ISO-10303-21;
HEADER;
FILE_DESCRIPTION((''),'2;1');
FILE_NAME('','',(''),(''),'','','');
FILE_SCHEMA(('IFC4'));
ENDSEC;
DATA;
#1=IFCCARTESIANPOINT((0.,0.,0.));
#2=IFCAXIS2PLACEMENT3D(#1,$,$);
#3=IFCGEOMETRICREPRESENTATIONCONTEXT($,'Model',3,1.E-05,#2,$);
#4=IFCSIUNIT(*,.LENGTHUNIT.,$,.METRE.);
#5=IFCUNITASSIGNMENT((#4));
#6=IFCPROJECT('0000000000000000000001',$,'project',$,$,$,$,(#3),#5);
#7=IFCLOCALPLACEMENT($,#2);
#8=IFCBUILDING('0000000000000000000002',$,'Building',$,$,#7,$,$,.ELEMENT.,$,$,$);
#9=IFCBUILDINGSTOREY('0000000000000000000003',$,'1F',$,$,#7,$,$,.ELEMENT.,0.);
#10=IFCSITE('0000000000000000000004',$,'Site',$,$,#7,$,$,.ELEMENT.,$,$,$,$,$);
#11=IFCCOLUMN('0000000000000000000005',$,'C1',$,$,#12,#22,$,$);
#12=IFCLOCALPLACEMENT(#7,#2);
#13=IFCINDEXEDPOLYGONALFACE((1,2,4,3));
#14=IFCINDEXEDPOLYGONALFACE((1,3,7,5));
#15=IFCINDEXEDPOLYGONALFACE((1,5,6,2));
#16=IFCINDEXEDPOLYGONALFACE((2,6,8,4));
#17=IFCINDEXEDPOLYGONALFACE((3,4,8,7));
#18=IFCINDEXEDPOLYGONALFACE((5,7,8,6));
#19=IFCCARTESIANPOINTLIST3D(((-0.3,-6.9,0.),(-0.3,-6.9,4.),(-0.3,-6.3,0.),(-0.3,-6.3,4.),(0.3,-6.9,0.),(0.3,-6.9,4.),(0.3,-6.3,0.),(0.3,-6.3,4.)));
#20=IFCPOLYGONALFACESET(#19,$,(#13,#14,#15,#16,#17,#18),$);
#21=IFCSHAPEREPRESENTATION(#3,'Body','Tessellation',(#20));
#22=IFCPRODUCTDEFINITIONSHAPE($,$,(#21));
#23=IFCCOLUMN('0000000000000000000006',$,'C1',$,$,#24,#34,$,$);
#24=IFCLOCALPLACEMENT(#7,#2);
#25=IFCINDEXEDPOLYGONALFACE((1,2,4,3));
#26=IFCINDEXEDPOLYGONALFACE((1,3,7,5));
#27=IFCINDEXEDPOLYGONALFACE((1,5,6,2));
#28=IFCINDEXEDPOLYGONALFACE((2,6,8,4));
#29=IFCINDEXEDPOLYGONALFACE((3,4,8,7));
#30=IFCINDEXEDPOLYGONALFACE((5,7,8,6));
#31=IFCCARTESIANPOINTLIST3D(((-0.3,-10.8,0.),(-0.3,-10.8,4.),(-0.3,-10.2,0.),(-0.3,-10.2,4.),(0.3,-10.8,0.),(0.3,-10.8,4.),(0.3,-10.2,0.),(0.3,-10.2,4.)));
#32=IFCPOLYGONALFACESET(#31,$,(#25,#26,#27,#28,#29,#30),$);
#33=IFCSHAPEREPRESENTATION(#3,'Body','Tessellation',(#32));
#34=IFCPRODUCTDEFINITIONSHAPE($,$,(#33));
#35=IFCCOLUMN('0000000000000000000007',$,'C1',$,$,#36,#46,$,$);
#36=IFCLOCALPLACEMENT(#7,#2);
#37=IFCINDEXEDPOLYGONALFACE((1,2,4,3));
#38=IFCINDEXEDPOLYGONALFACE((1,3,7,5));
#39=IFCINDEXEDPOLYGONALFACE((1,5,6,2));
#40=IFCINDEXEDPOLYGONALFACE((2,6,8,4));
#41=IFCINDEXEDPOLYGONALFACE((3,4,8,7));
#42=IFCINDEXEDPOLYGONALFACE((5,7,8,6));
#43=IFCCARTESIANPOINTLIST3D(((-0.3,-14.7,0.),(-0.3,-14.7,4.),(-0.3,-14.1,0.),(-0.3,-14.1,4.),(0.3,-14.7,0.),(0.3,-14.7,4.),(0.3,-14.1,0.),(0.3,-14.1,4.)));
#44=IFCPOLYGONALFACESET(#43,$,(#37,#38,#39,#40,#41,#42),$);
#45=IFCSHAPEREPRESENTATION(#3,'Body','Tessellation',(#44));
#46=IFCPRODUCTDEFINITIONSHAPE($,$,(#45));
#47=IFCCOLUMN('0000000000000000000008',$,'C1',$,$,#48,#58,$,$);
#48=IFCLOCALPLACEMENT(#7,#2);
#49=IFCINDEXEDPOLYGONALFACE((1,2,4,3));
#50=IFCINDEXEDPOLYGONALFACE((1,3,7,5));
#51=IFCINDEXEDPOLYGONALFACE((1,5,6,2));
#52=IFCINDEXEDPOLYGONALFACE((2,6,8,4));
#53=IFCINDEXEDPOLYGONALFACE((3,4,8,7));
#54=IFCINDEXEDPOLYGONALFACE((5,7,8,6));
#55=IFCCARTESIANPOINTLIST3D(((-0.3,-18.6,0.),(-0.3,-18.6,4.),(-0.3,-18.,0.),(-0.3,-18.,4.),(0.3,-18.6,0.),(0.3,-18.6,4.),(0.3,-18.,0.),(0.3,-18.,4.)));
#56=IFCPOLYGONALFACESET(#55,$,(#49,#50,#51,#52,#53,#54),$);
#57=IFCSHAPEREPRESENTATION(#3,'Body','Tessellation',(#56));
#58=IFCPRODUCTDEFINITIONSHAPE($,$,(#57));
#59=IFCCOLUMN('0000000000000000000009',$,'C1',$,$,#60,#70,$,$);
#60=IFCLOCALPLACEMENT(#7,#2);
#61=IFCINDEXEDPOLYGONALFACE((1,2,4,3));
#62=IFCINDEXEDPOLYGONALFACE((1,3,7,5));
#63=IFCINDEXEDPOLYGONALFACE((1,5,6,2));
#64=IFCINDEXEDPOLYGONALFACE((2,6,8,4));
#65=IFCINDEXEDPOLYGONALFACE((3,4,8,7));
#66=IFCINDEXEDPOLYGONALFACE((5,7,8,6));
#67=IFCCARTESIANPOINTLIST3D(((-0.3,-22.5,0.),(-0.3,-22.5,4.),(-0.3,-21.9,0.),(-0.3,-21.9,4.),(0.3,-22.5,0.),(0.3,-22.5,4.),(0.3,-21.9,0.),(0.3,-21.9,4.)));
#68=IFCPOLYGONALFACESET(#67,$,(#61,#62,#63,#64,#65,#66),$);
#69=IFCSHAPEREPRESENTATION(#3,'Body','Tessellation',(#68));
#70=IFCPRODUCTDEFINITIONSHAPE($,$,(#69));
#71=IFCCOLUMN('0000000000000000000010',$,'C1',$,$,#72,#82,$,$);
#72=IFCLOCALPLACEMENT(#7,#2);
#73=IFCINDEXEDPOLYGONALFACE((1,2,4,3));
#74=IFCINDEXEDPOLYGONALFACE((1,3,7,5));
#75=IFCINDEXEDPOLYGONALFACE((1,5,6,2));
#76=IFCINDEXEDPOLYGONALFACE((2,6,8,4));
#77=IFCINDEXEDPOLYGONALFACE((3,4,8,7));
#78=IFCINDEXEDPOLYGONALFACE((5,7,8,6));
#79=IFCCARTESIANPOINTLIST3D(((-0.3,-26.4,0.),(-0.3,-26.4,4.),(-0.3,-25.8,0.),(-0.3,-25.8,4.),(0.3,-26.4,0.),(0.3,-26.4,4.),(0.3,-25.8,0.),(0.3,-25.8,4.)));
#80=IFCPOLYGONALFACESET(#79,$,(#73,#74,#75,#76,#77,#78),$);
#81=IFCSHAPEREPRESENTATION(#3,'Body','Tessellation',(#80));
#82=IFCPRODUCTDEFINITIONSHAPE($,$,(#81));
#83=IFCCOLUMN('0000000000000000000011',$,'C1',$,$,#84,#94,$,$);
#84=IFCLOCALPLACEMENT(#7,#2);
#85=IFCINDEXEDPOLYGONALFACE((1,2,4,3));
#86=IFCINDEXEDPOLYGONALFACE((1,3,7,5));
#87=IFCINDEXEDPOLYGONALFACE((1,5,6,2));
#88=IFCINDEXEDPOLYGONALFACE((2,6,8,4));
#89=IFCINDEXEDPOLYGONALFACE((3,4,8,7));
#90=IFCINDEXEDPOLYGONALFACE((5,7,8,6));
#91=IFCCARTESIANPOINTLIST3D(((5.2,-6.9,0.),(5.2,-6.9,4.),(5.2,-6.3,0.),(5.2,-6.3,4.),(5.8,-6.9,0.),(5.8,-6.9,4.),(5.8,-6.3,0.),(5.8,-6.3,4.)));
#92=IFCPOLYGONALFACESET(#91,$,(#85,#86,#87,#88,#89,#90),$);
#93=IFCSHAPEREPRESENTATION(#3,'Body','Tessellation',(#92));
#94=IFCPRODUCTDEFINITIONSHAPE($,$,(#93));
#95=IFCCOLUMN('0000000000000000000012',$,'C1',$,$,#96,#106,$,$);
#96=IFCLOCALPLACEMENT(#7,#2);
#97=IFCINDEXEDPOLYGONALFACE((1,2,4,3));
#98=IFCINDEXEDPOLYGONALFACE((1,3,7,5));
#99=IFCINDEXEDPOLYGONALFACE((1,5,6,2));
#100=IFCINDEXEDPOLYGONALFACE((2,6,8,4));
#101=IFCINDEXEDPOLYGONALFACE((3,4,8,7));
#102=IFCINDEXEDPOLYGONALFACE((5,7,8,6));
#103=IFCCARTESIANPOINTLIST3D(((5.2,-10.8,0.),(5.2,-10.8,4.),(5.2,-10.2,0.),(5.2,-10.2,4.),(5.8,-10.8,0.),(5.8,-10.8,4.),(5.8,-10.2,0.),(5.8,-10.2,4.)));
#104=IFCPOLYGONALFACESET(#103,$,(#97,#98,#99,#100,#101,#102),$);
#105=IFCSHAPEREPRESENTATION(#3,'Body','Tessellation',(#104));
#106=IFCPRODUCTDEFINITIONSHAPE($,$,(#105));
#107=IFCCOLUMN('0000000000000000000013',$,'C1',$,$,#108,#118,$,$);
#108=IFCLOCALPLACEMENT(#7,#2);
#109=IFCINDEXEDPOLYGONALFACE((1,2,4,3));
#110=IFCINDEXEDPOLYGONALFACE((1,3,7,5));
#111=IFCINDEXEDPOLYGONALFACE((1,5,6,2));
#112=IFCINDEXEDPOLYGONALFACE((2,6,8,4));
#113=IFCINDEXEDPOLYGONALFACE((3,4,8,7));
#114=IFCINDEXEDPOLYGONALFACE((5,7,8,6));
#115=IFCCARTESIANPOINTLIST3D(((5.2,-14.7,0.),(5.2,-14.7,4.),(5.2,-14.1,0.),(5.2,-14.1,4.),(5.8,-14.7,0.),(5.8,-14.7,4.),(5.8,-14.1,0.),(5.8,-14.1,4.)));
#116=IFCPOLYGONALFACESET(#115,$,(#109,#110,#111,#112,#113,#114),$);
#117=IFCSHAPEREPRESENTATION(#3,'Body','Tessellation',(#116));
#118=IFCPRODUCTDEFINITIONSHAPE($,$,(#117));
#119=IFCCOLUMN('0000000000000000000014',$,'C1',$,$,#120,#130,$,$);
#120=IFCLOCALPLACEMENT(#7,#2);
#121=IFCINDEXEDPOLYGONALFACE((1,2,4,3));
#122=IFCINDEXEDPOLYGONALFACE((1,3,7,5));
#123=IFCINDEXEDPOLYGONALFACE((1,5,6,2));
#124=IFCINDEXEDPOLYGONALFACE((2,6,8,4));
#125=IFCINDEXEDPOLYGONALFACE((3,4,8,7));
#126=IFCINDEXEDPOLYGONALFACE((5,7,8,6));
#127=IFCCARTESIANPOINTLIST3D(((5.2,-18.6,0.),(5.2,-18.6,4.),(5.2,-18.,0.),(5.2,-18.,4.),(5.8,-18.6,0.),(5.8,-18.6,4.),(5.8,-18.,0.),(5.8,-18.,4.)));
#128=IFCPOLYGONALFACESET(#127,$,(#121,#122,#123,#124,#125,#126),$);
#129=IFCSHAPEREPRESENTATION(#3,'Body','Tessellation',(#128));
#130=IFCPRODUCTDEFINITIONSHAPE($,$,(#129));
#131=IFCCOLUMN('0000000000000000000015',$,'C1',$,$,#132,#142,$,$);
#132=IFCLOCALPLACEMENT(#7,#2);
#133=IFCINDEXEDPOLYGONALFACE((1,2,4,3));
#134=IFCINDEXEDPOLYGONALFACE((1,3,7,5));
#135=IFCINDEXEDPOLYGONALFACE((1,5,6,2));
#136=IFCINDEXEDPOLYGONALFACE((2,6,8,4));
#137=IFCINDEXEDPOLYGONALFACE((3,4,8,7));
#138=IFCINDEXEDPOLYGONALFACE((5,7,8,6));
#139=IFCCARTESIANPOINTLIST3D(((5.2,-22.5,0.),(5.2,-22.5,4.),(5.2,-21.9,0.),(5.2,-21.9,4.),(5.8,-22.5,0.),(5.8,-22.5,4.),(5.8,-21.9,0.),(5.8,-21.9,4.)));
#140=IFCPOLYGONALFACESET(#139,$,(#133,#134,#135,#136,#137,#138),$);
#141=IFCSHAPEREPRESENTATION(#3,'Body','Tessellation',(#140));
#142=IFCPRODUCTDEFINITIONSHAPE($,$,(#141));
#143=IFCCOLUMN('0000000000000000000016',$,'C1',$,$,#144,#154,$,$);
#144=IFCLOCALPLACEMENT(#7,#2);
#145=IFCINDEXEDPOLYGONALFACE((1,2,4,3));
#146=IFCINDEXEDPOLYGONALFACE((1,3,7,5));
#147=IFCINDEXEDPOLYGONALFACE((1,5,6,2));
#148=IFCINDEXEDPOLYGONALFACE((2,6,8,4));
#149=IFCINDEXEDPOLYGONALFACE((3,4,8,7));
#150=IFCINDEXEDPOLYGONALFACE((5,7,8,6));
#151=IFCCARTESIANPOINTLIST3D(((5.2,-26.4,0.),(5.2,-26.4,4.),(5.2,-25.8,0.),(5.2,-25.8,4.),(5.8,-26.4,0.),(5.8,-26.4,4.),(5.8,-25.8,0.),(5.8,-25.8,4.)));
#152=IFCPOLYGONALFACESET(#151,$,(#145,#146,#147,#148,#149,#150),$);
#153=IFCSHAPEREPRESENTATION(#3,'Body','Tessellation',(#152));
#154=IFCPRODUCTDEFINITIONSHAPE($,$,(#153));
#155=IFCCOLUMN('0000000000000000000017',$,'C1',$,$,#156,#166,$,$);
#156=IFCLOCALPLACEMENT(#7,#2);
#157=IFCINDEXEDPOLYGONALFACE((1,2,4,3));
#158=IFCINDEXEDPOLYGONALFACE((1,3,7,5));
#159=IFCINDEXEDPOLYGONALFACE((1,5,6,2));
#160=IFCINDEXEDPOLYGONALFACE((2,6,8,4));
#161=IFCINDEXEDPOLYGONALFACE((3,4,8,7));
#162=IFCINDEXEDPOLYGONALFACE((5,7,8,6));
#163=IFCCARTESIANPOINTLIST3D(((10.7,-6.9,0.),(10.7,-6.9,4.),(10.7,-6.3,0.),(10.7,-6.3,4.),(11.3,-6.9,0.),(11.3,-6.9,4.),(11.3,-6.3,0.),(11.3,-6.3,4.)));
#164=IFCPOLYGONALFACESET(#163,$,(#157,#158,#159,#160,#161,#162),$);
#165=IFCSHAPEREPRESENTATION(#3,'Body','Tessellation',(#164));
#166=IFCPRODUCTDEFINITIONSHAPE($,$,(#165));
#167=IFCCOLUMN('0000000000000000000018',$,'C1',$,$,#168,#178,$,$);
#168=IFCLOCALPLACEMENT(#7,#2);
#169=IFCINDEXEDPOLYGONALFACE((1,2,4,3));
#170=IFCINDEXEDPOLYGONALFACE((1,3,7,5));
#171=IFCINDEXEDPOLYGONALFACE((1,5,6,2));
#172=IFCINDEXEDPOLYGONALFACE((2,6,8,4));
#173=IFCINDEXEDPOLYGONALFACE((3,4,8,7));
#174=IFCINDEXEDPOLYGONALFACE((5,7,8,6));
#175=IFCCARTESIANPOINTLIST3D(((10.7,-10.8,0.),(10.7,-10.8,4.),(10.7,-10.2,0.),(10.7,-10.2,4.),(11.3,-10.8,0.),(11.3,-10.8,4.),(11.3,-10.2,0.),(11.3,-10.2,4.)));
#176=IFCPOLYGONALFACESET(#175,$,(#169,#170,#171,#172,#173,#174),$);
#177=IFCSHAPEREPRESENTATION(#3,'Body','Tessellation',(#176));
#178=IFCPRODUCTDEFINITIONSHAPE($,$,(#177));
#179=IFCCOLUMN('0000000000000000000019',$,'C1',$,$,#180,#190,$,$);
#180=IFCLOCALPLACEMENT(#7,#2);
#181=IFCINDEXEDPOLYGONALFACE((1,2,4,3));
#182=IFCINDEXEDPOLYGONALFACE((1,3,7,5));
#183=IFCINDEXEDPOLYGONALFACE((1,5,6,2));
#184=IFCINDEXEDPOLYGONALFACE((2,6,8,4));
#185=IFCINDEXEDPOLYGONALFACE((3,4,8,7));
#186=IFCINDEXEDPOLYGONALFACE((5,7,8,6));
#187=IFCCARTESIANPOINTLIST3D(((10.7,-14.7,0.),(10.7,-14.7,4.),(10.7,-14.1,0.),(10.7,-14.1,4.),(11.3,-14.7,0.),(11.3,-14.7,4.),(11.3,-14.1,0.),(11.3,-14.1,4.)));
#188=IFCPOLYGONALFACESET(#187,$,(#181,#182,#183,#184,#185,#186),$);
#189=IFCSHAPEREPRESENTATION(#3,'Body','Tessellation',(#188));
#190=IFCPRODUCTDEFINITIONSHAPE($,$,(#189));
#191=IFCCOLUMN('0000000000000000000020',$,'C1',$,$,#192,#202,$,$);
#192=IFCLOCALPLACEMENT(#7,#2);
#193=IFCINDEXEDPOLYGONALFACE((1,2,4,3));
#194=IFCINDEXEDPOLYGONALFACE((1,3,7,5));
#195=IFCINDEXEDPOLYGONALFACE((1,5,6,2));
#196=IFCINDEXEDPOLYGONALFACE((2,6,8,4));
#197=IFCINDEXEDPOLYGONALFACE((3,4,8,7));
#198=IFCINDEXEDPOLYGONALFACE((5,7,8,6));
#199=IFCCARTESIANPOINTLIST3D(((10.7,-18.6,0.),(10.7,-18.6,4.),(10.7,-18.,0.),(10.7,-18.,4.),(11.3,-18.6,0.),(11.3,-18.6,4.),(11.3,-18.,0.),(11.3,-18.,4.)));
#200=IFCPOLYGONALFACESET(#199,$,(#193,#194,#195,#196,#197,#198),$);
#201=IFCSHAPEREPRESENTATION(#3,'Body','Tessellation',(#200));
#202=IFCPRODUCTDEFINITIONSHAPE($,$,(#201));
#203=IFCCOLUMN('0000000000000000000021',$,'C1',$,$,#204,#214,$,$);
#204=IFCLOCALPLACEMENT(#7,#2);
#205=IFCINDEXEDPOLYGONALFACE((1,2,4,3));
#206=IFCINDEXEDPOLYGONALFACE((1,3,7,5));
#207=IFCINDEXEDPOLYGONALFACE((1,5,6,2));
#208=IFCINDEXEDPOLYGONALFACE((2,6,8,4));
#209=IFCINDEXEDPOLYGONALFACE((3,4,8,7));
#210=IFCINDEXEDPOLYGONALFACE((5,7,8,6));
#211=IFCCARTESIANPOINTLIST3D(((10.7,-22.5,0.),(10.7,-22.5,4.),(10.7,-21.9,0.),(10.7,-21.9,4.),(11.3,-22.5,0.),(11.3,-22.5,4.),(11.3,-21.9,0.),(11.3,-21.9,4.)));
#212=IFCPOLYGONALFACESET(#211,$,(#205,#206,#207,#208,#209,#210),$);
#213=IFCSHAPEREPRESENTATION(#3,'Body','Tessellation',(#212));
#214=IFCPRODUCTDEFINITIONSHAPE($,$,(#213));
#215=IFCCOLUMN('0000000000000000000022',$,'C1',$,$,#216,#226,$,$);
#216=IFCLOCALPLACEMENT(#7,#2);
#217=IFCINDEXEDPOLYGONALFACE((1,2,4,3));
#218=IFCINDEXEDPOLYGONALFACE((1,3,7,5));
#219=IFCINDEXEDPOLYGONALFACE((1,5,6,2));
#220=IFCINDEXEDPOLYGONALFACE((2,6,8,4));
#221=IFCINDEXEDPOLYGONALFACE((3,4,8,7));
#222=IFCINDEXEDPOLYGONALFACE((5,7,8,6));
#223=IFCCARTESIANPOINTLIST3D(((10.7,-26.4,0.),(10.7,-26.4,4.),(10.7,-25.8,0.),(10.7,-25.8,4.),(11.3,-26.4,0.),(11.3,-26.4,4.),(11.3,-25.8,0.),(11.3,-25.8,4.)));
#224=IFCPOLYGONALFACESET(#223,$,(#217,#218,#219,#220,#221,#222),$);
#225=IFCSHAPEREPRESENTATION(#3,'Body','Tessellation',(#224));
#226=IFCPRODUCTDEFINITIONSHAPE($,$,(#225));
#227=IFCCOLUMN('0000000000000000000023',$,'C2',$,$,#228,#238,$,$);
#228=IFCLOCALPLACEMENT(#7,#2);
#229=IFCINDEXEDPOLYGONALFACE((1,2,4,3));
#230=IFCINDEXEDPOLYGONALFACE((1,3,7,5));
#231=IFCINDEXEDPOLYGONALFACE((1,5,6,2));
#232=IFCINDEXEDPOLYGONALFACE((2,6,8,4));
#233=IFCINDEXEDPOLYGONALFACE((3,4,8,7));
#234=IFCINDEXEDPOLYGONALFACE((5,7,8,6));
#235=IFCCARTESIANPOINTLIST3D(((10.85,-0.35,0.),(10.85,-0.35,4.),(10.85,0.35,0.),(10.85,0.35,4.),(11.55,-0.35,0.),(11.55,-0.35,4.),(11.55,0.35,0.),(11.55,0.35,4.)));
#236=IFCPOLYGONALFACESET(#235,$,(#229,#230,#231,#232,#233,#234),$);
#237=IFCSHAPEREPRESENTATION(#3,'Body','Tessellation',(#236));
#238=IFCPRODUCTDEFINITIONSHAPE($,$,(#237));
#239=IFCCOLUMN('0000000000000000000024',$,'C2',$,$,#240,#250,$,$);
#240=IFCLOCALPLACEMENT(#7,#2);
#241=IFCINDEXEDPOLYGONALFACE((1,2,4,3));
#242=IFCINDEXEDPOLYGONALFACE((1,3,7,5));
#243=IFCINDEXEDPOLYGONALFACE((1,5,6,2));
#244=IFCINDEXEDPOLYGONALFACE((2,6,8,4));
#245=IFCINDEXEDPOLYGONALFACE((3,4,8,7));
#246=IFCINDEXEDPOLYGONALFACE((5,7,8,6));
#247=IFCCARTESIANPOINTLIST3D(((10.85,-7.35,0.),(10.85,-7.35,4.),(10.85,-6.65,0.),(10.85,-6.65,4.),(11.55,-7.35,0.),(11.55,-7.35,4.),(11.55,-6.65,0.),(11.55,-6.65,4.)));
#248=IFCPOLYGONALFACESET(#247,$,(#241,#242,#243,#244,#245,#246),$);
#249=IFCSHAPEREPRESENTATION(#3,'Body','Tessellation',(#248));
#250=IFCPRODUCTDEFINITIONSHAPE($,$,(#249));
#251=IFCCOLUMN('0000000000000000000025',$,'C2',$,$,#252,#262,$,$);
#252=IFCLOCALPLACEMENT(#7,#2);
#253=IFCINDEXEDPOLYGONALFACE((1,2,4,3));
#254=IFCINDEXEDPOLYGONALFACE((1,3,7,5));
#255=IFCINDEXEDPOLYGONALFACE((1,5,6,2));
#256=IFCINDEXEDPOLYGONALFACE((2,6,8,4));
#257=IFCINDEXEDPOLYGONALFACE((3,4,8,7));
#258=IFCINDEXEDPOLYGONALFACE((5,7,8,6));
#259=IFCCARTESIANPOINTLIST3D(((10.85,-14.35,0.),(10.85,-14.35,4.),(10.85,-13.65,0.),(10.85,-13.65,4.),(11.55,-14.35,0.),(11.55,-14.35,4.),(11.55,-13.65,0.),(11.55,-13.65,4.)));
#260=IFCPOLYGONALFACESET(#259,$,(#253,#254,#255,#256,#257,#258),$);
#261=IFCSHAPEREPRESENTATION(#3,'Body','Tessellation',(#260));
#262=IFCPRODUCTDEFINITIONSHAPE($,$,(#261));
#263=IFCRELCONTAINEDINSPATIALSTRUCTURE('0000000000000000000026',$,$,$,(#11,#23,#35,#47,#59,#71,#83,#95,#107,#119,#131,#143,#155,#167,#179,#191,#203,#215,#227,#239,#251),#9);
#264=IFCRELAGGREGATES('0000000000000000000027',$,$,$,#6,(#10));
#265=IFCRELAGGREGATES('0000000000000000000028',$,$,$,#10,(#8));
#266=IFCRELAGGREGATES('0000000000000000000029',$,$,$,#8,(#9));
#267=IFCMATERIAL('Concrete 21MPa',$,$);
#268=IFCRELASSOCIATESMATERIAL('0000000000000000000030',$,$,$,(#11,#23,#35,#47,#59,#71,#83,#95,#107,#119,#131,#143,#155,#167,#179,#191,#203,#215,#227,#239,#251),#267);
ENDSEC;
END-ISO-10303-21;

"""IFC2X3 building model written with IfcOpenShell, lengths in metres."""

from ifc_helpers import new_model, si_unit, frame, origin, origin_2d, place, context, project, spatial, rectangle, extrude, material, element, save


model = new_model("IFC2X3")

# Units and contexts
model_context = context("Model", 3, precision=1e-05, world=origin())
ifc_project = project(units=[si_unit("LENGTHUNIT", "METRE")], contexts=[model_context])

# Site, building, storey
placement = place(None, origin())
site = spatial("IfcSite", under=ifc_project, at=placement, Name="Site", CompositionType="ELEMENT")
building = spatial("IfcBuilding", under=site, at=placement, Name="Building", CompositionType="ELEMENT")
storey = spatial("IfcBuildingStorey", under=building, at=placement, Name="1F", CompositionType="ELEMENT", Elevation=0.0)

# Columns
ifc_material_1 = material(Name="Concrete 21MPa")
for number, where, name in (
    (1, (0.0, -6.6, 0.0), "C1"),
    (2, (0.0, -10.5, 0.0), "C1"),
    (3, (0.0, -14.4, 0.0), "C1"),
    (4, (0.0, -18.3, 0.0), "C1"),
    (5, (0.0, -22.2, 0.0), "C1"),
    (6, (0.0, -26.1, 0.0), "C1"),
    (7, (5.5, -6.6, 0.0), "C1"),
    (8, (5.5, -10.5, 0.0), "C1"),
    (9, (5.5, -14.4, 0.0), "C1"),
    (10, (5.5, -18.3, 0.0), "C1"),
    (11, (5.5, -22.2, 0.0), "C1"),
    (12, (5.5, -26.1, 0.0), "C1"),
    (13, (11.0, -6.6, 0.0), "C1"),
    (14, (11.0, -10.5, 0.0), "C1"),
    (15, (11.0, -14.4, 0.0), "C1"),
    (16, (11.0, -18.3, 0.0), "C1"),
    (17, (11.0, -22.2, 0.0), "C1"),
    (18, (11.0, -26.1, 0.0), "C1"),
):
    element("IfcColumn", number, at=place(None, frame(where)), inside=storey, material=ifc_material_1, Name=name, context=model_context, shape_type="SweptSolid", body=[
        extrude(rectangle(XDim=0.6, YDim=0.6, at=origin_2d()), origin(), (0.0, 0.0, 1.0), 4.0),
    ])
for number, where, name in (
    (19, (11.2, 0.0, 0.0), "C2"),
    (20, (11.2, -7.0, 0.0), "C2"),
    (21, (11.2, -14.0, 0.0), "C2"),
):
    element("IfcColumn", number, at=place(None, frame(where)), inside=storey, material=ifc_material_1, Name=name, context=model_context, shape_type="SweptSolid", body=[
        extrude(rectangle(XDim=0.7, YDim=0.7, at=origin_2d()), origin(), (0.0, 0.0, 1.0), 4.0),
    ])

save(model, "model.ifc")
